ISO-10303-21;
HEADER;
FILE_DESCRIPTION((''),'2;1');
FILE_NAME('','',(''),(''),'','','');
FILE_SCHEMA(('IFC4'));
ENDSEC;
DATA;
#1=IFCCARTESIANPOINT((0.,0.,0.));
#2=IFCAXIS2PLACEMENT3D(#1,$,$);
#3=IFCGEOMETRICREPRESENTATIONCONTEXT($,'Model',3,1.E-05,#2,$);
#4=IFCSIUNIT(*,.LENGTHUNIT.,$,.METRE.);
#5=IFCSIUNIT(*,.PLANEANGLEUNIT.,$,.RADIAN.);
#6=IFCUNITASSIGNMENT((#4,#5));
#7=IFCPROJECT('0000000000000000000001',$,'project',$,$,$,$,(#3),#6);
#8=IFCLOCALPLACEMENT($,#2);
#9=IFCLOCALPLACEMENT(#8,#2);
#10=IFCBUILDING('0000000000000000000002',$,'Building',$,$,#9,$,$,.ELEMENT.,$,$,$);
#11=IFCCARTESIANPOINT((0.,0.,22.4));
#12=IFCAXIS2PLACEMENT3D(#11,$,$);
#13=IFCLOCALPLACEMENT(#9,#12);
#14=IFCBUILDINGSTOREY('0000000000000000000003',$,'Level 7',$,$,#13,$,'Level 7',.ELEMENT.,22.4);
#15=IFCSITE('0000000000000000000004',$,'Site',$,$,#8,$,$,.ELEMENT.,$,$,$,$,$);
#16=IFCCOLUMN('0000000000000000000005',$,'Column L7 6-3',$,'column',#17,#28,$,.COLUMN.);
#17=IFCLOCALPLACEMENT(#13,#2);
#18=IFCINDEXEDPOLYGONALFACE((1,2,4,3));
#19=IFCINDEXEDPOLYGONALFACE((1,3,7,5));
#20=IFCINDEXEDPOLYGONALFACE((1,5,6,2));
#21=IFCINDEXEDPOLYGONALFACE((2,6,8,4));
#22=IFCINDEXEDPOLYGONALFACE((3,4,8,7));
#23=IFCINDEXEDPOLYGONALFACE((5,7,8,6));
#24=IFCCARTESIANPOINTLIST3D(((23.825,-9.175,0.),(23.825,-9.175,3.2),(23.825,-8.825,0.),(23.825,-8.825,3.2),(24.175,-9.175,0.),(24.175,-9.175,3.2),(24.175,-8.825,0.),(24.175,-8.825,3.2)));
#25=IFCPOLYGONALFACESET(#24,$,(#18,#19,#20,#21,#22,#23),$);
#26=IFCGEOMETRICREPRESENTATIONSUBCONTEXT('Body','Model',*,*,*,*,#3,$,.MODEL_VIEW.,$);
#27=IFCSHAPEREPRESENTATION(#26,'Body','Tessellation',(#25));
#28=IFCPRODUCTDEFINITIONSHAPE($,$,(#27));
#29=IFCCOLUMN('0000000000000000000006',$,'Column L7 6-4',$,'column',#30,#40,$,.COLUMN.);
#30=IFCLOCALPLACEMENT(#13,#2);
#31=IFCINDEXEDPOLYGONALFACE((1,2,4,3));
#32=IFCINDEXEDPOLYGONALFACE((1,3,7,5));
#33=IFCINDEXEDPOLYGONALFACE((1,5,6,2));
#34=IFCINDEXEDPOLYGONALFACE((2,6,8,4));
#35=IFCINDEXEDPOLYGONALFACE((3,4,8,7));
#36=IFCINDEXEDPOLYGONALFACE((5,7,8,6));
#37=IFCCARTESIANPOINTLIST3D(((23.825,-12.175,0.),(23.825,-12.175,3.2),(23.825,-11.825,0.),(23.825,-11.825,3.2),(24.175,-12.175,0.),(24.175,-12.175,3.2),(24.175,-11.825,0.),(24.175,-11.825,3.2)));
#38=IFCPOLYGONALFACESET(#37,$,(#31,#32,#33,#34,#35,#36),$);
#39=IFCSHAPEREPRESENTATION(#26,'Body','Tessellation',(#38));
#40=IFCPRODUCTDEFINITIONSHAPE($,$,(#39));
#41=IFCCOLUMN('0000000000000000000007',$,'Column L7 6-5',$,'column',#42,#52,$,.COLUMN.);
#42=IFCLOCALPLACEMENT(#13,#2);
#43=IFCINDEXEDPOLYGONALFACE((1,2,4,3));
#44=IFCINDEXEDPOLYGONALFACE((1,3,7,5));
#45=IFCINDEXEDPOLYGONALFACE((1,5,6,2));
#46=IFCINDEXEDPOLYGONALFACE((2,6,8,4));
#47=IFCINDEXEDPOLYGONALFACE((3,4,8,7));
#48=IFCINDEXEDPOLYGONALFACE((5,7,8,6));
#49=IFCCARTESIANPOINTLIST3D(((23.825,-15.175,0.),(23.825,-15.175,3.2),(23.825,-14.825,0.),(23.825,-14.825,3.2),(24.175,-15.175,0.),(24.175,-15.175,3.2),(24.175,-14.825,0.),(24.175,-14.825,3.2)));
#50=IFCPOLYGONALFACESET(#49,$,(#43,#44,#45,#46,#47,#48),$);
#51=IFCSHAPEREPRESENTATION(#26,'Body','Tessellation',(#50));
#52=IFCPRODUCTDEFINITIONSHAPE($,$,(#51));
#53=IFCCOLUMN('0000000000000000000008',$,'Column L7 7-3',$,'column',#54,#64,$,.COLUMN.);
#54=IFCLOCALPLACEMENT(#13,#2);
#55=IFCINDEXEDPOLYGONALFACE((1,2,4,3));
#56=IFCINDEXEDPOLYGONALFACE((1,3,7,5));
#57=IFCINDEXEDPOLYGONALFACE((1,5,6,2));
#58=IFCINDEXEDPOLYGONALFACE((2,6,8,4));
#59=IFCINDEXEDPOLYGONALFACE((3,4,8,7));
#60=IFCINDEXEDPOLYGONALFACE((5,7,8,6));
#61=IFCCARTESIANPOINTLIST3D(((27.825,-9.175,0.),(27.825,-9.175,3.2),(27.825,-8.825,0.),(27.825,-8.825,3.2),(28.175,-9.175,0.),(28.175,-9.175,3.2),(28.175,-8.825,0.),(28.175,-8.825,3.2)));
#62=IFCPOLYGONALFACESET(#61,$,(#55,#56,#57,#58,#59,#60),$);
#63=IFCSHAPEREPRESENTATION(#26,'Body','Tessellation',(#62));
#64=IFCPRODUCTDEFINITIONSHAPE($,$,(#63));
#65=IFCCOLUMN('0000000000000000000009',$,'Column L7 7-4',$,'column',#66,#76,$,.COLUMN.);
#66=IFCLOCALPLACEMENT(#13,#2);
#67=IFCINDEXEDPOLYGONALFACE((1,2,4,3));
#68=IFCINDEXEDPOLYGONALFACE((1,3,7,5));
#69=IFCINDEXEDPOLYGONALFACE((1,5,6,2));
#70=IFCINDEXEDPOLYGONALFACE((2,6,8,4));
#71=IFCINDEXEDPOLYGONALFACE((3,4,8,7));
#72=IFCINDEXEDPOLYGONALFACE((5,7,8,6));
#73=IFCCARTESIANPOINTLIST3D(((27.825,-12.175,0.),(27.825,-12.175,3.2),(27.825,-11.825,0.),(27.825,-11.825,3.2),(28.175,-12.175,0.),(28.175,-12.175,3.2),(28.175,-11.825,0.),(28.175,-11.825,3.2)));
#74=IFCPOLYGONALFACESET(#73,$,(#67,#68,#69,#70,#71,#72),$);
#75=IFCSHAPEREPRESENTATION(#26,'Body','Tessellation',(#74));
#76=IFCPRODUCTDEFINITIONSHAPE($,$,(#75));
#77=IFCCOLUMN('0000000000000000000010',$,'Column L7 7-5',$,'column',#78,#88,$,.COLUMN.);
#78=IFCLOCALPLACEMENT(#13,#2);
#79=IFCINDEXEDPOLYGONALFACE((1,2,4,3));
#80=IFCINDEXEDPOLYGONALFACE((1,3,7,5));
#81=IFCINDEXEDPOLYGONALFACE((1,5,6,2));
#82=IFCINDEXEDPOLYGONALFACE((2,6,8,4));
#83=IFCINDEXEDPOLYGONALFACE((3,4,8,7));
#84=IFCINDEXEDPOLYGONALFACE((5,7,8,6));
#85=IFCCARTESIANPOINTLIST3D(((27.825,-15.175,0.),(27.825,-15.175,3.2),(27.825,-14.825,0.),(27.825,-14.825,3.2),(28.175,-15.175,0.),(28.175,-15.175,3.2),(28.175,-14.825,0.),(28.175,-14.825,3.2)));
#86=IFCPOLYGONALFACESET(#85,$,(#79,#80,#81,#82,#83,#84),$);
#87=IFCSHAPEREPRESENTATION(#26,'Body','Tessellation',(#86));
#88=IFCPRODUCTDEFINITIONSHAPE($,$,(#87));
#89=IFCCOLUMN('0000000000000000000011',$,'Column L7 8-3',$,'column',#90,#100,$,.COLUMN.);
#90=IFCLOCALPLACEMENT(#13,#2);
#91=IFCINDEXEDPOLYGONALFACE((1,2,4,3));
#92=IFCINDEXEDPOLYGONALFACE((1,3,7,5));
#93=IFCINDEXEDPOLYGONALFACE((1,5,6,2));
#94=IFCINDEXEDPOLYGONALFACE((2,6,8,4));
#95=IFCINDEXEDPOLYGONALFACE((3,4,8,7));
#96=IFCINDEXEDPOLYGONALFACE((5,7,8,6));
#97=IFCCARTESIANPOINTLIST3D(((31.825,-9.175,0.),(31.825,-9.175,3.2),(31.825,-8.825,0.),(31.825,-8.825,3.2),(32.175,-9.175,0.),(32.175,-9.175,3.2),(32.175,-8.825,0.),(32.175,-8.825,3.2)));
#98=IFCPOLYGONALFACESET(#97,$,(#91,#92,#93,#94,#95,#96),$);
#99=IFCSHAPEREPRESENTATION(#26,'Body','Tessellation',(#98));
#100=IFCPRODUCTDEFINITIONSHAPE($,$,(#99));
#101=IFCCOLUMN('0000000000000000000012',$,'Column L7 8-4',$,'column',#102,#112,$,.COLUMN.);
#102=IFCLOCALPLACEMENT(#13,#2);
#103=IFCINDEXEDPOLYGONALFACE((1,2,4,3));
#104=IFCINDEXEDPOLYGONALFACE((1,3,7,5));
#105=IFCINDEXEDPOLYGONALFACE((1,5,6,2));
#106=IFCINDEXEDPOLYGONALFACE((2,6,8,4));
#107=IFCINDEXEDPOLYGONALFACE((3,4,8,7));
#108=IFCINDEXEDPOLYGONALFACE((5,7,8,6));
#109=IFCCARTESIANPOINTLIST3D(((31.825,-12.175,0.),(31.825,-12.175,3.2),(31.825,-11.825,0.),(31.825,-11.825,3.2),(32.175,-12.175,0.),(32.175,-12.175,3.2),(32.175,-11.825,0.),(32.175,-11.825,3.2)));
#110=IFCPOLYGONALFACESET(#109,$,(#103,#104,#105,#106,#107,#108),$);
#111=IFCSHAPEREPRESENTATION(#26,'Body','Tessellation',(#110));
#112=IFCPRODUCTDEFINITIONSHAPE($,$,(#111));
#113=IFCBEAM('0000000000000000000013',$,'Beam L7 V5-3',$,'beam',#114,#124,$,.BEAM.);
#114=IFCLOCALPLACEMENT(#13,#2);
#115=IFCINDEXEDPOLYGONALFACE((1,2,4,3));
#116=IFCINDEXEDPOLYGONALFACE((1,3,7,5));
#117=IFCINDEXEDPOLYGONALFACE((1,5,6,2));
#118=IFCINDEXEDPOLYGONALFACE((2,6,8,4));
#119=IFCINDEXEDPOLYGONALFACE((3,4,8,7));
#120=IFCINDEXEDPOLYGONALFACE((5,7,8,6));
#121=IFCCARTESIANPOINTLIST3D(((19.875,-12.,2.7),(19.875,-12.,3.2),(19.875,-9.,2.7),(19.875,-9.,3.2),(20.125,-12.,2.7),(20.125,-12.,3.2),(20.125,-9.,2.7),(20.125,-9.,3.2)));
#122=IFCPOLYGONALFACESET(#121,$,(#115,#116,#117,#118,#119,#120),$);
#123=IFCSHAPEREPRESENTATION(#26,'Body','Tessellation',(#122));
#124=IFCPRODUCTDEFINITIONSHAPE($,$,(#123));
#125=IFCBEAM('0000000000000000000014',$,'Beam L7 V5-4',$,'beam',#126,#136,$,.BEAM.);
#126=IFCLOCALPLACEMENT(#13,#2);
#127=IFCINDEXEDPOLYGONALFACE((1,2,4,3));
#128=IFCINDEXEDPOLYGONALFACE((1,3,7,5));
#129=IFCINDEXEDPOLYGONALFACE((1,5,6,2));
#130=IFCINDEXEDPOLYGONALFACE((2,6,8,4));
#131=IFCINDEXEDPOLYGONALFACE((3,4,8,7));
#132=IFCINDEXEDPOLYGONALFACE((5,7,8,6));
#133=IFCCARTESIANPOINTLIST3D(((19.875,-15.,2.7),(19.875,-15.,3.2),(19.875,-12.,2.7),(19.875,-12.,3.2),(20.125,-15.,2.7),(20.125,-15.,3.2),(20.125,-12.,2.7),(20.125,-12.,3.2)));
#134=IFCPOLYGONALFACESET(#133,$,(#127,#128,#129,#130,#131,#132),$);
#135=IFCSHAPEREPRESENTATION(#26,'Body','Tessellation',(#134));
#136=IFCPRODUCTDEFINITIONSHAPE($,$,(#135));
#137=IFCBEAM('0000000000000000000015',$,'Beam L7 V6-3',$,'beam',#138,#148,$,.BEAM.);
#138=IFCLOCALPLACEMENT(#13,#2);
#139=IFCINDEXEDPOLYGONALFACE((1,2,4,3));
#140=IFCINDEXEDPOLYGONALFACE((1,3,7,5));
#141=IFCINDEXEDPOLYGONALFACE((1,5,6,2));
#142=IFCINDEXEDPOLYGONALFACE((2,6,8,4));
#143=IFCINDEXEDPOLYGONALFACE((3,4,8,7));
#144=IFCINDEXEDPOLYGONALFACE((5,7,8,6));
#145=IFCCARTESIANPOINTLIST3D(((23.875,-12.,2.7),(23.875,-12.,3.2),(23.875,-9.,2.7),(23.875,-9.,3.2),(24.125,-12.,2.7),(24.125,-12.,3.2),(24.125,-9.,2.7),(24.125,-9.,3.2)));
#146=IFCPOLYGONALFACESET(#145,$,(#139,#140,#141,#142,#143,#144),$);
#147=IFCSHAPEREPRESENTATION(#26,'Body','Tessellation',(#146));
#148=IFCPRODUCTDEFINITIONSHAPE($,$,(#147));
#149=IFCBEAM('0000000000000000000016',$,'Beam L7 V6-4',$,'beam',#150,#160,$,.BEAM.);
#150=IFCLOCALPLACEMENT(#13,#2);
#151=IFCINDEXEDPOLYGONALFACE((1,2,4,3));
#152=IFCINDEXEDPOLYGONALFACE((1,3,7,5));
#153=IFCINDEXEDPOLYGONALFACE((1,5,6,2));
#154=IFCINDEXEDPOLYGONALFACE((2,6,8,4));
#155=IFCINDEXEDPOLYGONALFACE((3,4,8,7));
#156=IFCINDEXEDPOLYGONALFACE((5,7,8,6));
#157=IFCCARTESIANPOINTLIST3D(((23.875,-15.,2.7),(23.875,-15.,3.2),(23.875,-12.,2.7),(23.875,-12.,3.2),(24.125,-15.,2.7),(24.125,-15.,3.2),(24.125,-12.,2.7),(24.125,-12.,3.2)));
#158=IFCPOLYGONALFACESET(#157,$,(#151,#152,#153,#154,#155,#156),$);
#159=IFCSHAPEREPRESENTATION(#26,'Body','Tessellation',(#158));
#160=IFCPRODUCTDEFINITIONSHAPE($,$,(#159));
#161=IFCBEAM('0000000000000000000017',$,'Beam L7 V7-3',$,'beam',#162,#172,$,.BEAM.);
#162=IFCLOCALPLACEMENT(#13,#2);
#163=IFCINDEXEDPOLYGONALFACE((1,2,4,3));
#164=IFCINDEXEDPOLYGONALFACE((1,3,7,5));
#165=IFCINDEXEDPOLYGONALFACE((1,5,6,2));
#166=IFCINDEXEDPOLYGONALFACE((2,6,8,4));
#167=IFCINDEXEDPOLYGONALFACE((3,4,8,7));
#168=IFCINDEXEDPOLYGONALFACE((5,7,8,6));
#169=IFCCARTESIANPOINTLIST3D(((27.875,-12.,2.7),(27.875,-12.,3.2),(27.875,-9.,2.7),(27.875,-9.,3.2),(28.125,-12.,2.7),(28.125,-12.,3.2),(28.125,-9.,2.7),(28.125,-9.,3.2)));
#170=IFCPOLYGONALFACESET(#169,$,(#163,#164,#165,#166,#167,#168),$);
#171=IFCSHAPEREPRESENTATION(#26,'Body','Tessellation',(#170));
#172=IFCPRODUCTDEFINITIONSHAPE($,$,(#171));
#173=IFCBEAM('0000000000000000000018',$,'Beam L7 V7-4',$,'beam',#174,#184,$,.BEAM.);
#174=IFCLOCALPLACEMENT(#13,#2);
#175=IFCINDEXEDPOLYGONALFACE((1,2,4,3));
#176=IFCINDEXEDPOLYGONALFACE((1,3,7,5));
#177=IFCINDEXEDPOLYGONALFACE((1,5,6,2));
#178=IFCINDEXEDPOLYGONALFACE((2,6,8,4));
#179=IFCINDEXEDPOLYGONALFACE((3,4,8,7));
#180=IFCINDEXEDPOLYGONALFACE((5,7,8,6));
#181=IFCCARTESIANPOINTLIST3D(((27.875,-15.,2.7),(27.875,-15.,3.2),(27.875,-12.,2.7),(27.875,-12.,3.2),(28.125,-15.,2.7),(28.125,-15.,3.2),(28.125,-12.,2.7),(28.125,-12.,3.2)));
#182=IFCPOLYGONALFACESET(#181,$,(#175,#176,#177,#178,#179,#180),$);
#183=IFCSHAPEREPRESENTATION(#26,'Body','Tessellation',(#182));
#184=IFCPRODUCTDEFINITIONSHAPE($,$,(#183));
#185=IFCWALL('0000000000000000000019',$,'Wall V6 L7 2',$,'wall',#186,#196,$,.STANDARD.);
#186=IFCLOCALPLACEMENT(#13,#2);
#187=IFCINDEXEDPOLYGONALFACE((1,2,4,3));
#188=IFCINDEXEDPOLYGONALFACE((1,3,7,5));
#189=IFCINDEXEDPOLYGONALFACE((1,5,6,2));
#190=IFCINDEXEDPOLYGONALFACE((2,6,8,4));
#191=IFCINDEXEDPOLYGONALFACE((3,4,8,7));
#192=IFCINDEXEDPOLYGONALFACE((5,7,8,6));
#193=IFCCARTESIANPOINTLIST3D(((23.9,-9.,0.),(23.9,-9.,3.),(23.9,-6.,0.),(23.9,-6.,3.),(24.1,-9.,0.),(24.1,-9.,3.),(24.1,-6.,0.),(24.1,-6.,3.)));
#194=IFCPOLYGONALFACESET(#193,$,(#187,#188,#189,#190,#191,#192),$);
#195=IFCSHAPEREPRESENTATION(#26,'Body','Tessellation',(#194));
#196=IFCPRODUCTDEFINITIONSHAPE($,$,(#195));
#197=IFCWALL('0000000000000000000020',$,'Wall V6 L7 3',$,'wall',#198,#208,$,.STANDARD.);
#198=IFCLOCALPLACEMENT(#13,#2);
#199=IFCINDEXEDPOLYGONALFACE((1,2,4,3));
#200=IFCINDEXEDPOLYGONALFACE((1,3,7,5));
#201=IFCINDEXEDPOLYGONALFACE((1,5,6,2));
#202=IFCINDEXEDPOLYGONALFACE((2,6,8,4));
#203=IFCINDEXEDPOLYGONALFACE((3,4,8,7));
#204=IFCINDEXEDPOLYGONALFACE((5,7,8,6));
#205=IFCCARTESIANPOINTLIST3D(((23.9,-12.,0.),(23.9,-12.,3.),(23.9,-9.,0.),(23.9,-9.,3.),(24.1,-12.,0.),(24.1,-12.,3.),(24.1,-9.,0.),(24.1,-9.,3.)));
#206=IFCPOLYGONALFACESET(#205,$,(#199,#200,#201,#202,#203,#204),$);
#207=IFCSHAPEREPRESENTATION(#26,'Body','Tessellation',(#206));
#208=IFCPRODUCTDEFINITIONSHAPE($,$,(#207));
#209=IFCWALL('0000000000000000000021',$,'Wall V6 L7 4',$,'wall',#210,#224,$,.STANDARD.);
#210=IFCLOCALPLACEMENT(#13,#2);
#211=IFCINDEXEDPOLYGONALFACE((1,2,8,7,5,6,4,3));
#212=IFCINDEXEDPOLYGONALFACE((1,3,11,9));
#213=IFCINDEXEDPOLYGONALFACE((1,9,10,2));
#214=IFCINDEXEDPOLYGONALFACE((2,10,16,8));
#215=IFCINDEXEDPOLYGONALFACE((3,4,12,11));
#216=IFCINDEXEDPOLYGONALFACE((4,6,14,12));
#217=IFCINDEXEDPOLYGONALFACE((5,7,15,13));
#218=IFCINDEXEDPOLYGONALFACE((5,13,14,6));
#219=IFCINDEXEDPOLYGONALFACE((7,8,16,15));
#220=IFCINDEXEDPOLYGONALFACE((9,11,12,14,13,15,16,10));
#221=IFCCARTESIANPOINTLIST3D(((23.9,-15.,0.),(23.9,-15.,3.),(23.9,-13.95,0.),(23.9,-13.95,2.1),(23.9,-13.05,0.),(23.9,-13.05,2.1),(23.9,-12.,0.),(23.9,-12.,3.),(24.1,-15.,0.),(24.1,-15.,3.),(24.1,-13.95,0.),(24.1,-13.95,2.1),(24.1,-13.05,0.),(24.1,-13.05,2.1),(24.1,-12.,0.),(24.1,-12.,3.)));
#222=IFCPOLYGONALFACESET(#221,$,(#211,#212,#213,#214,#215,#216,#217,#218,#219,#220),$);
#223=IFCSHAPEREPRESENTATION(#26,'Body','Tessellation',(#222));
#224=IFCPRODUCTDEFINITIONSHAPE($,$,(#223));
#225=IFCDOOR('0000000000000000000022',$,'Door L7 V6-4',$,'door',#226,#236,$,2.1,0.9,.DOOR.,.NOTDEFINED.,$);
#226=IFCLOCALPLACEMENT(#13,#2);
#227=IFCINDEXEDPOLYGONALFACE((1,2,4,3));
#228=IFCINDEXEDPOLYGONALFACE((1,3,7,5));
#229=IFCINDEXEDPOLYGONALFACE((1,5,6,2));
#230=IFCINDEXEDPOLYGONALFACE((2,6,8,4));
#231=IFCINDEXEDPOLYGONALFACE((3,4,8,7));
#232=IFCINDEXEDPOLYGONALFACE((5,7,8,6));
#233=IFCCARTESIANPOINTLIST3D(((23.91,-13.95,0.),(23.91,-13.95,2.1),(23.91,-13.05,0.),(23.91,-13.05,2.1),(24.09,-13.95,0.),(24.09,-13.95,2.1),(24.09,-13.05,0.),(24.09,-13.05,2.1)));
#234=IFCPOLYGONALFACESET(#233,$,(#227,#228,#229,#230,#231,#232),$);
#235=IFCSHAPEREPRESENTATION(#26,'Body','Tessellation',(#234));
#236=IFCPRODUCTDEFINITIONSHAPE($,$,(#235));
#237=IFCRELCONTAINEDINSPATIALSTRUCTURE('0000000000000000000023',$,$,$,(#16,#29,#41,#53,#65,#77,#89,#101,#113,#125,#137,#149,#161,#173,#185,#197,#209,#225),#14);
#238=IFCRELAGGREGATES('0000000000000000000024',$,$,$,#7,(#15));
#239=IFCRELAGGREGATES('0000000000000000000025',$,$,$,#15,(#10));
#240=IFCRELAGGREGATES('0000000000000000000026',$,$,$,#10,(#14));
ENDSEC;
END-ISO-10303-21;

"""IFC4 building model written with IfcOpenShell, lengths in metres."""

from ifc_helpers import new_model, si_unit, frame, frame_2d, origin, origin_2d, place, context, subcontext, project, spatial, rectangle, extrude, element, fill, save


model = new_model("IFC4")

# Units and contexts
model_context = context("Model", 3, precision=1e-05, world=origin())
body_context = subcontext(model_context, "Body", "Model", "MODEL_VIEW")
ifc_project = project(units=[si_unit("LENGTHUNIT", "METRE"), si_unit("PLANEANGLEUNIT", "RADIAN")], contexts=[model_context])

# Site, building, storey
site_placement = place(None, origin())
site = spatial("IfcSite", under=ifc_project, at=site_placement, Name="Site", CompositionType="ELEMENT")
building_placement = place(site_placement, origin())
building = spatial("IfcBuilding", under=site, at=building_placement, Name="Building", CompositionType="ELEMENT")
storey_placement = place(building_placement, frame((0.0, 0.0, 22.4)))
storey = spatial("IfcBuildingStorey", under=building, at=storey_placement, Name="Level 7", LongName="Level 7", CompositionType="ELEMENT", Elevation=22.4)

# Columns
for number, where, name in (
    (1, (24.0, -9.0, 0.0), "Column L7 6-3"),
    (2, (24.0, -12.0, 0.0), "Column L7 6-4"),
    (3, (24.0, -15.0, 0.0), "Column L7 6-5"),
    (4, (28.0, -9.0, 0.0), "Column L7 7-3"),
    (5, (28.0, -12.0, 0.0), "Column L7 7-4"),
    (6, (28.0, -15.0, 0.0), "Column L7 7-5"),
    (7, (32.0, -9.0, 0.0), "Column L7 8-3"),
    (8, (32.0, -12.0, 0.0), "Column L7 8-4"),
):
    element("IfcColumn", number, at=place(storey_placement, frame(where)), inside=storey, Name=name, ObjectType="column", PredefinedType="COLUMN", context=body_context, shape_type="SweptSolid", body=[
        extrude(rectangle(XDim=0.35, YDim=0.35, at=origin_2d()), origin(), (0.0, 0.0, 1.0), 3.2),
    ])

# Beams
for number, where, z_axis, x_axis, name in (
    (9, (20.0, -9.0, 2.95), (0.0, -1.0, 0.0), (0.0, 0.0, 1.0), "Beam L7 V5-3"),
    (10, (20.0, -12.0, 2.95), (0.0, -1.0, 0.0), (0.0, 0.0, 1.0), "Beam L7 V5-4"),
    (11, (24.0, -9.0, 2.95), (0.0, -1.0, 0.0), (0.0, 0.0, 1.0), "Beam L7 V6-3"),
    (12, (24.0, -12.0, 2.95), (0.0, -1.0, 0.0), (0.0, 0.0, 1.0), "Beam L7 V6-4"),
    (13, (28.0, -9.0, 2.95), (0.0, -1.0, 0.0), (0.0, 0.0, 1.0), "Beam L7 V7-3"),
    (14, (28.0, -12.0, 2.95), (0.0, -1.0, 0.0), (0.0, 0.0, 1.0), "Beam L7 V7-4"),
):
    element("IfcBeam", number, at=place(storey_placement, frame(where, z_axis=z_axis, x_axis=x_axis)), inside=storey, Name=name, ObjectType="beam", PredefinedType="BEAM", context=body_context, shape_type="SweptSolid", body=[
        extrude(rectangle(XDim=0.5, YDim=0.25, at=origin_2d()), origin(), (0.0, 0.0, 1.0), 3.0),
    ])

# Walls
for number, where, z_axis, x_axis, name in (
    (15, (24.0, -6.0, 0.0), (0.0, 0.0, 1.0), (0.0, -1.0, 0.0), "Wall V6 L7 2"),
    (16, (24.0, -9.0, 0.0), (0.0, 0.0, 1.0), (0.0, -1.0, 0.0), "Wall V6 L7 3"),
):
    element("IfcWall", number, at=place(storey_placement, frame(where, z_axis=z_axis, x_axis=x_axis)), inside=storey, Name=name, ObjectType="wall", PredefinedType="STANDARD", context=body_context, shape_type="SweptSolid", body=[
        extrude(rectangle(XDim=3.0, YDim=0.2, at=frame_2d((1.5, 0.0))), origin(), (0.0, 0.0, 1.0), 3.0),
    ])

# Wall, opening, door
wall_1_placement = place(storey_placement, frame((24.0, -12.0, 0.0), z_axis=(0.0, 0.0, 1.0), x_axis=(0.0, -1.0, 0.0)))
wall_1 = element("IfcWall", 17, at=wall_1_placement, inside=storey, Name="Wall V6 L7 4", ObjectType="wall", PredefinedType="STANDARD", context=body_context, shape_type="SweptSolid", body=[
    extrude(rectangle(XDim=3.0, YDim=0.2, at=frame_2d((1.5, 0.0))), origin(), (0.0, 0.0, 1.0), 3.0),
])
opening_1_placement = place(storey_placement, frame((24.0, -13.5, 0.0), z_axis=(0.0, 0.0, 1.0), x_axis=(0.0, -1.0, 0.0)))
opening_1 = element("IfcOpeningElement", 18, at=opening_1_placement, cuts=wall_1, ObjectType="Opening", PredefinedType="OPENING", context=body_context, shape_type="SweptSolid", body=[
    extrude(rectangle(XDim=0.9, YDim=0.22, at=origin_2d()), origin(), (0.0, 0.0, 1.0), 2.1),
])
door_1_placement = place(storey_placement, frame((24.0, -13.5, 0.0), z_axis=(0.0, 0.0, 1.0), x_axis=(0.0, -1.0, 0.0)))
door_1 = element("IfcDoor", 19, at=door_1_placement, inside=storey, Name="Door L7 V6-4", ObjectType="door", OperationType="NOTDEFINED", OverallHeight=2.1, OverallWidth=0.9, PredefinedType="DOOR", context=body_context, shape_type="SweptSolid", body=[
    extrude(rectangle(XDim=0.9, YDim=0.18, at=origin_2d()), origin(), (0.0, 0.0, 1.0), 2.1),
])
fill(opening_1, door_1)

save(model, "model.ifc")
